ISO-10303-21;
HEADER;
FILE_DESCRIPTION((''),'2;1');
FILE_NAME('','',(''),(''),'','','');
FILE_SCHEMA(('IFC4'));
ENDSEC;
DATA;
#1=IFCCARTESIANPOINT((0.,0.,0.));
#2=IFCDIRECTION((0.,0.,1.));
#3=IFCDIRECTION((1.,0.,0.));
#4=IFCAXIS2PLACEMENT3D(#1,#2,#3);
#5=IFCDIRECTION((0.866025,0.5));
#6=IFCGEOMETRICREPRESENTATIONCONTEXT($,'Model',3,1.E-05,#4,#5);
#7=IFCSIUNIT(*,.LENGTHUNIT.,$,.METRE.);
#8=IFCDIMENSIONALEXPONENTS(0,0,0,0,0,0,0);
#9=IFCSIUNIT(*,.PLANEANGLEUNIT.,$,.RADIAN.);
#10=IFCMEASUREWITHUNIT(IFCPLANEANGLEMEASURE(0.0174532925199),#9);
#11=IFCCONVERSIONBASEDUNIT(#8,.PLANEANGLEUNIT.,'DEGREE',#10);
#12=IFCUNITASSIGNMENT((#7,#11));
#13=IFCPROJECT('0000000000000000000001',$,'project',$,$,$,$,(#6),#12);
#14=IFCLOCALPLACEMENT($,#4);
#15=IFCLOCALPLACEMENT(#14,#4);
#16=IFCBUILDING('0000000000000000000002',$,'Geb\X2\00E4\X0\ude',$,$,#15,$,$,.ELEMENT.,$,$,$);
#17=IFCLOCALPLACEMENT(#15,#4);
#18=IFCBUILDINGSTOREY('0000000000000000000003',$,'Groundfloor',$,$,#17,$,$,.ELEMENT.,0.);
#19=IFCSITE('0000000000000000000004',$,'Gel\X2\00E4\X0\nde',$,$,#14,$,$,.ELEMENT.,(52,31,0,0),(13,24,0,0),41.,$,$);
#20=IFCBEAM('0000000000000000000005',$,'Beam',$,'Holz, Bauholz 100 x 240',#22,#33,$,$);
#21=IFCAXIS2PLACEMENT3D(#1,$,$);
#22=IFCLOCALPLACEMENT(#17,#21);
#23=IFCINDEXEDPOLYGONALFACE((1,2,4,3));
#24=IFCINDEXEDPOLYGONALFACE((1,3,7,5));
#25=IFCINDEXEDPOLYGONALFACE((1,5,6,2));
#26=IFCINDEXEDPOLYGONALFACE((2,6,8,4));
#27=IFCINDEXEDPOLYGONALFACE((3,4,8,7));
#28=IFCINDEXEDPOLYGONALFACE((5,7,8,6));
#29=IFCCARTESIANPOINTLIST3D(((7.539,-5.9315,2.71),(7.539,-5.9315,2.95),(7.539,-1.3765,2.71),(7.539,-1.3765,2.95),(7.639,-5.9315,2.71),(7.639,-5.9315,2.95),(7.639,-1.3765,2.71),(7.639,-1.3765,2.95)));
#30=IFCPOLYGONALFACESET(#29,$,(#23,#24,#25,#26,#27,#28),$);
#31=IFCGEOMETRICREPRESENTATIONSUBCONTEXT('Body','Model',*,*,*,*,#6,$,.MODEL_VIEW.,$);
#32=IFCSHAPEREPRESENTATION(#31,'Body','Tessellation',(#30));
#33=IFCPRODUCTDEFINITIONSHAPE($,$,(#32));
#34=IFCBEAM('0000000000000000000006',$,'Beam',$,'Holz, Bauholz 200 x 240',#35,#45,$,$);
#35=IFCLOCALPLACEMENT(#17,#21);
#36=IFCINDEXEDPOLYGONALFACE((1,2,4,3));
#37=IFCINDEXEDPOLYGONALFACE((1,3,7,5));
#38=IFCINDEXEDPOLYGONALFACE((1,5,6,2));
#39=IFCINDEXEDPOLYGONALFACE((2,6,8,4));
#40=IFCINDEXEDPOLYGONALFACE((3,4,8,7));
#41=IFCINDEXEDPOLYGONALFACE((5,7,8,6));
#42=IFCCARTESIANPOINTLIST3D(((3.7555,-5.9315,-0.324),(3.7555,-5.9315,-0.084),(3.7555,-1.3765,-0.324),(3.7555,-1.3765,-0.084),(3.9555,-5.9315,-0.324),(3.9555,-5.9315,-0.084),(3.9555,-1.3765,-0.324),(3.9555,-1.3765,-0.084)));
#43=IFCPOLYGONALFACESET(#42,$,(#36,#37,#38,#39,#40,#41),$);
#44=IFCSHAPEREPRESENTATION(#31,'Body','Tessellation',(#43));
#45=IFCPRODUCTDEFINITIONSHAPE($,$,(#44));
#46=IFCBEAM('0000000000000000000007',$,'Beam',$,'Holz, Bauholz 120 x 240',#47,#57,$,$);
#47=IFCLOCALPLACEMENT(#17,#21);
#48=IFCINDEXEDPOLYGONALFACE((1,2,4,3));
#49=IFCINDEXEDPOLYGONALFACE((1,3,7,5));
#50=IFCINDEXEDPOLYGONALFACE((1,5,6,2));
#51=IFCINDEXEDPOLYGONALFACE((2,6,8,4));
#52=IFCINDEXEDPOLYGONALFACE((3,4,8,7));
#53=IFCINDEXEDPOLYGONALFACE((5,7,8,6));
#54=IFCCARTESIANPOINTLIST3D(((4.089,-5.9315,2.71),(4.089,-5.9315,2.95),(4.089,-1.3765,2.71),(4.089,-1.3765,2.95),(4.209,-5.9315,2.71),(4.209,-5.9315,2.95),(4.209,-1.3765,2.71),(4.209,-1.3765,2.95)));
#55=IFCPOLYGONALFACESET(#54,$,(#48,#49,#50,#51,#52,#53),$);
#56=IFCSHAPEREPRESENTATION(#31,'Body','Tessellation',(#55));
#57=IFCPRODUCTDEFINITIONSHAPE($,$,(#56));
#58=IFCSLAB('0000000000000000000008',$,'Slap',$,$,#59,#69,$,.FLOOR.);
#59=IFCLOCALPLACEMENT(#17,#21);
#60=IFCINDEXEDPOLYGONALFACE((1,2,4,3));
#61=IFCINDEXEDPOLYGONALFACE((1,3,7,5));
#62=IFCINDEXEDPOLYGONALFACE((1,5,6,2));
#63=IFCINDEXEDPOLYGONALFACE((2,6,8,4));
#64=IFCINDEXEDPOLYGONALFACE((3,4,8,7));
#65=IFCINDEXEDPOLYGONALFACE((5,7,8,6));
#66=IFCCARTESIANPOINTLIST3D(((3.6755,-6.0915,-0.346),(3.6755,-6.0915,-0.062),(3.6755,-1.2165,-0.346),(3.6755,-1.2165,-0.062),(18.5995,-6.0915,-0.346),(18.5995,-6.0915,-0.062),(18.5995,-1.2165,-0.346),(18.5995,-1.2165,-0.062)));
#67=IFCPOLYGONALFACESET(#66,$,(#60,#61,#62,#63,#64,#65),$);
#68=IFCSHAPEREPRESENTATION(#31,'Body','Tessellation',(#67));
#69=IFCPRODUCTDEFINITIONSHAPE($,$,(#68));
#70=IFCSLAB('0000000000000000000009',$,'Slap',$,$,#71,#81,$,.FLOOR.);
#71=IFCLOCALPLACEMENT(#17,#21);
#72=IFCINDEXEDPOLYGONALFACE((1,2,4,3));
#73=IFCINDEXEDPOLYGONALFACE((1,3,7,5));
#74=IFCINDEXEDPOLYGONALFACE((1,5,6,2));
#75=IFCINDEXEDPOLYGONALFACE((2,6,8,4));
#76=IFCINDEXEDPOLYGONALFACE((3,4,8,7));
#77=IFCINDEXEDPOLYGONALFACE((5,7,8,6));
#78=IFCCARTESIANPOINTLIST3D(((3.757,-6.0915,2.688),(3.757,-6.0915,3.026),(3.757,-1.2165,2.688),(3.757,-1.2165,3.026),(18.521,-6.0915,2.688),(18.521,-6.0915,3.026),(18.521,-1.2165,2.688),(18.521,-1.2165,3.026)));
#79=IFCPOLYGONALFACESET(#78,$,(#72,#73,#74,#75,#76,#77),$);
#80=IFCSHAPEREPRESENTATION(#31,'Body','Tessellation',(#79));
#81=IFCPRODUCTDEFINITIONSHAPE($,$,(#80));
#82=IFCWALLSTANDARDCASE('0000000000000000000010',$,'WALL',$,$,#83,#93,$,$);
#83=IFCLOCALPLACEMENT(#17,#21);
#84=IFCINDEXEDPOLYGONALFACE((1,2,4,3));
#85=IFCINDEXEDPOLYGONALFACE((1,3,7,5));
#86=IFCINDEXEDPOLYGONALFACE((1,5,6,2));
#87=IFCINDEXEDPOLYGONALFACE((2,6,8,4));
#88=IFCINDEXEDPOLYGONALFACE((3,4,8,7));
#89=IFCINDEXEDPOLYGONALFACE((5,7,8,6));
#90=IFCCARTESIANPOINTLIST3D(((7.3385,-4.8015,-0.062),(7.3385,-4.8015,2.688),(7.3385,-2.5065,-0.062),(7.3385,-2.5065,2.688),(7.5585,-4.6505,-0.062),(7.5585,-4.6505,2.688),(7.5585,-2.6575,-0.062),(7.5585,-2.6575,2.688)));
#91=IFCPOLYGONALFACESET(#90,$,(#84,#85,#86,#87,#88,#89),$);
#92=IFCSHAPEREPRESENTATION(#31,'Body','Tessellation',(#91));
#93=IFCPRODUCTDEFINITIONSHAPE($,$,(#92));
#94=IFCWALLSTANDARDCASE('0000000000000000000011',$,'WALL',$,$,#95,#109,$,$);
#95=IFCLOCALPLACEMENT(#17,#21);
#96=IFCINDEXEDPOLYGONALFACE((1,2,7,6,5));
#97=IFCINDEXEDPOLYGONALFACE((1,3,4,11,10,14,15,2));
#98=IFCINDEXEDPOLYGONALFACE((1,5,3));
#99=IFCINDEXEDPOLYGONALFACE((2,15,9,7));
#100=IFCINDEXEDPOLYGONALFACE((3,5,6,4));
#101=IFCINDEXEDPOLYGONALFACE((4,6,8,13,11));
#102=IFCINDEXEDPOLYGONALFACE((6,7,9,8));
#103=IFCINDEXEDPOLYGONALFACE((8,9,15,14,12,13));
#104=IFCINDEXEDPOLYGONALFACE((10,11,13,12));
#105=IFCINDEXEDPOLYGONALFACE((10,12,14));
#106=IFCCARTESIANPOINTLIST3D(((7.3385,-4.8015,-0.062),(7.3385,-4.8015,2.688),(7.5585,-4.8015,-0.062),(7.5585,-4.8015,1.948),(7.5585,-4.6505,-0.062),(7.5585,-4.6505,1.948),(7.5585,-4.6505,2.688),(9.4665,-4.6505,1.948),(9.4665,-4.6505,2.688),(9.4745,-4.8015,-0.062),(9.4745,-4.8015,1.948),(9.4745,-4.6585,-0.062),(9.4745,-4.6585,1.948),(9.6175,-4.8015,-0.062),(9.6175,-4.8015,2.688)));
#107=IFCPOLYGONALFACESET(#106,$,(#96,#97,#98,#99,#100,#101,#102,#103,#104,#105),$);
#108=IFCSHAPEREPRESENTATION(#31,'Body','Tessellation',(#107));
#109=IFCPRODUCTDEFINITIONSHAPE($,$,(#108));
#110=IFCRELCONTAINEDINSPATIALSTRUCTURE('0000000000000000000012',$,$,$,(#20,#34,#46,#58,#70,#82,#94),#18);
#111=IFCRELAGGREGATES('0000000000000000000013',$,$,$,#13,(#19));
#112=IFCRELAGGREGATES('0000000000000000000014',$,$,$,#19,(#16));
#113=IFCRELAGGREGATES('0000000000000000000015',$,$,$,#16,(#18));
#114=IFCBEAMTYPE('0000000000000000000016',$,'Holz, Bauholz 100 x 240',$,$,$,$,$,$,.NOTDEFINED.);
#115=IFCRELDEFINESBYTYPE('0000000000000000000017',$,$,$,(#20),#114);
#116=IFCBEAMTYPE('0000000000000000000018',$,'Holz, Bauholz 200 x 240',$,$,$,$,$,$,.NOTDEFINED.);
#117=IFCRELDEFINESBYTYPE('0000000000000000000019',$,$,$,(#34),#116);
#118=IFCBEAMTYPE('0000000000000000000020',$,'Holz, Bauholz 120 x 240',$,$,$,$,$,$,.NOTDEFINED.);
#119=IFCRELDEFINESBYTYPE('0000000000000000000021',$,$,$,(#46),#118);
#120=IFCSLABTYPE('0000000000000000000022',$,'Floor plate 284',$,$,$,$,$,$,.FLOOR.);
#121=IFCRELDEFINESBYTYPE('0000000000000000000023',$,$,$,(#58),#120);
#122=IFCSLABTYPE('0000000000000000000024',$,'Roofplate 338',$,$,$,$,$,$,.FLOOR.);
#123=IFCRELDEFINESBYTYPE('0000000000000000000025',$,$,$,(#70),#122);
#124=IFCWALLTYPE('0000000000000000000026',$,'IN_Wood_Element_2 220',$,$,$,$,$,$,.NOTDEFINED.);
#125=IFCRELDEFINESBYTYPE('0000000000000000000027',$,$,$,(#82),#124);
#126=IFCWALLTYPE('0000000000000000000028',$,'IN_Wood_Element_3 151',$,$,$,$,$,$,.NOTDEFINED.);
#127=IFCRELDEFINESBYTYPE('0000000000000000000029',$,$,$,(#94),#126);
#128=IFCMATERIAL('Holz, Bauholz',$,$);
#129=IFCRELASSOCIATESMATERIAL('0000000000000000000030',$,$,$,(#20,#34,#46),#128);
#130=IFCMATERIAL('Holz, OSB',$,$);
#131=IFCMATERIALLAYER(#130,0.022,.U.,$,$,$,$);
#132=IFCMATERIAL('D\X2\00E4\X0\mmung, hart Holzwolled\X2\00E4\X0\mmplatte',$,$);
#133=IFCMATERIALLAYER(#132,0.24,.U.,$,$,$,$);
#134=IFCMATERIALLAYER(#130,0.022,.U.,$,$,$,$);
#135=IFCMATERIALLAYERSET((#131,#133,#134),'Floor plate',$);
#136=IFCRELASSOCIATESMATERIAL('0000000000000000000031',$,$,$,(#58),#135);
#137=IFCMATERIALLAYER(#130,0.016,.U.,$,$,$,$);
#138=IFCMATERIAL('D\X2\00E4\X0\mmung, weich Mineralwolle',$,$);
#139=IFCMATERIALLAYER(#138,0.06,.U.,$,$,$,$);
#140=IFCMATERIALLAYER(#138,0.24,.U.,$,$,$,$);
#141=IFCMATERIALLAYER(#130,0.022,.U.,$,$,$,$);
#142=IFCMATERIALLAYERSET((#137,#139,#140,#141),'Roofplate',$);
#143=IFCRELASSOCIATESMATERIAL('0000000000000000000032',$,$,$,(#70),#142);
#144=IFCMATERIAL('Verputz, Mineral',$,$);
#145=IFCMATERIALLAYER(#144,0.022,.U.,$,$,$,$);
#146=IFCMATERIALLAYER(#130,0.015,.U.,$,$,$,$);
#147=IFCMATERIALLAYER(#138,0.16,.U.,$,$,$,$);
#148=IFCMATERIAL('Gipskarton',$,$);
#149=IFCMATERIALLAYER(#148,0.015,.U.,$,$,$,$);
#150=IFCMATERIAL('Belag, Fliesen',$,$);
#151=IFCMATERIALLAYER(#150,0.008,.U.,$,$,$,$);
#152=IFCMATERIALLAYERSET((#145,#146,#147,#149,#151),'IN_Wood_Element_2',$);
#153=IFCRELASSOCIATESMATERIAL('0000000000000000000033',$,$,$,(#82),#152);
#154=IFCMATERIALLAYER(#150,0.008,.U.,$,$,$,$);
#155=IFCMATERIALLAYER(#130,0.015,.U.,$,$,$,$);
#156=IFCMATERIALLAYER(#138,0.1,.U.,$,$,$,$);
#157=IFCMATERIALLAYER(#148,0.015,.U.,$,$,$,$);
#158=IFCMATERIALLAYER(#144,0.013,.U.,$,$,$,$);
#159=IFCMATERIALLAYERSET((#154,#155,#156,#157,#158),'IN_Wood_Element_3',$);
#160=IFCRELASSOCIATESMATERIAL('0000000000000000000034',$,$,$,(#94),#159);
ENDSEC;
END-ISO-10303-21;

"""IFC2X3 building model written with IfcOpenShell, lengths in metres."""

from ifc_helpers import new_model, entity, si_unit, converted_unit, direction, frame, frame_2d, origin_with_axes, origin_2d_with_axis, place, context, subcontext, project, spatial, polyline, rectangle, outline, extrude, material, layer, layer_set, layer_usage, type_object, element, save


model = new_model("IFC2X3")

# Units and contexts
model_context = context("Model", 3, precision=1e-05, world=origin_with_axes(), true_north=direction((0.866025, 0.5)))
body_context = subcontext(model_context, "Body", "Model", "MODEL_VIEW")
ifc_project = project(units=[si_unit("LENGTHUNIT", "METRE"), converted_unit("PLANEANGLEUNIT", "DEGREE", entity("IfcPlaneAngleMeasure", 0.0174532925199), si_unit("PLANEANGLEUNIT", "RADIAN"), dimensions=[0, 0, 0, 0, 0, 0, 0])], contexts=[model_context])

# Site, building, storey
site_placement = place(None, origin_with_axes())
site = spatial("IfcSite", under=ifc_project, at=site_placement, Name="Gelände", CompositionType="ELEMENT", RefLatitude=(52, 31, 0, 0), RefLongitude=(13, 24, 0, 0), RefElevation=41.0)
building_placement = place(site_placement, origin_with_axes())
building = spatial("IfcBuilding", under=site, at=building_placement, Name="Gebäude", CompositionType="ELEMENT")
storey_placement = place(building_placement, origin_with_axes())
storey = spatial("IfcBuildingStorey", under=building, at=storey_placement, Name="Groundfloor", CompositionType="ELEMENT", Elevation=0.0)

# Shared definitions
ifc_material_1 = material(Name="Holz, Bauholz")

# Beams
beam_type_1 = type_object("IfcBeamType", Name="Holz, Bauholz 100 x 240", PredefinedType="NOTDEFINED")
for number, where, z_axis, x_axis, name in (
    (1, (7.589, -5.9315, 2.95), (0.0, 0.0, 1.0), (1.0, 0.0, 0.0), "Beam"),
):
    element("IfcBeam", number, at=place(storey_placement, frame(where, z_axis=z_axis, x_axis=x_axis)), inside=storey, type_object=beam_type_1, material=ifc_material_1, Name=name, ObjectType="Holz, Bauholz 100 x 240", context=body_context, shape_type="SweptSolid", body=[
        extrude(rectangle(XDim=0.24, YDim=0.1, at=frame_2d((-0.12, 0.0), x_axis=(1.0, 0.0))), frame((0.0, 0.0, 0.0), z_axis=(0.0, 1.0, 0.0), x_axis=(0.0, 0.0, 1.0)), (0.0, 0.0, 1.0), 4.555),
    ])
beam_type_2 = type_object("IfcBeamType", Name="Holz, Bauholz 200 x 240", PredefinedType="NOTDEFINED")
beam_1_placement = place(storey_placement, frame((3.8555, -5.9315, -0.084), z_axis=(0.0, 0.0, 1.0), x_axis=(1.0, 0.0, 0.0)))
element("IfcBeam", 2, at=beam_1_placement, inside=storey, type_object=beam_type_2, material=ifc_material_1, Name="Beam", ObjectType="Holz, Bauholz 200 x 240", context=body_context, shape_type="SweptSolid", body=[
    extrude(rectangle(XDim=0.24, YDim=0.2, at=frame_2d((-0.12, 0.0), x_axis=(1.0, 0.0))), frame((0.0, 0.0, 0.0), z_axis=(0.0, 1.0, 0.0), x_axis=(0.0, 0.0, 1.0)), (0.0, 0.0, 1.0), 4.555),
])
beam_type_3 = type_object("IfcBeamType", Name="Holz, Bauholz 120 x 240", PredefinedType="NOTDEFINED")
beam_2_placement = place(storey_placement, frame((4.149, -5.9315, 2.95), z_axis=(0.0, 0.0, 1.0), x_axis=(1.0, 0.0, 0.0)))
element("IfcBeam", 3, at=beam_2_placement, inside=storey, type_object=beam_type_3, material=ifc_material_1, Name="Beam", ObjectType="Holz, Bauholz 120 x 240", context=body_context, shape_type="SweptSolid", body=[
    extrude(rectangle(XDim=0.24, YDim=0.12, at=frame_2d((-0.12, 0.0), x_axis=(1.0, 0.0))), frame((0.0, 0.0, 0.0), z_axis=(0.0, 1.0, 0.0), x_axis=(0.0, 0.0, 1.0)), (0.0, 0.0, 1.0), 4.555),
])

# Slabs
ifc_material_2 = material(Name="Holz, OSB")
ifc_layer_1 = layer(ifc_material_2, 0.022, ventilated="UNKNOWN")
ifc_material_3 = material(Name="Dämmung, hart Holzwolledämmplatte")
ifc_layer_2 = layer(ifc_material_3, 0.24, ventilated="UNKNOWN")
ifc_layer_3 = layer(ifc_material_2, 0.022, ventilated="UNKNOWN")
ifc_layer_set_1 = layer_set([ifc_layer_1, ifc_layer_2, ifc_layer_3], Name="Floor plate")
ifc_layer_usage_1 = layer_usage(ifc_layer_set_1, "AXIS3", "NEGATIVE", 0.284)
slab_type_1 = type_object("IfcSlabType", Name="Floor plate 284", PredefinedType="FLOOR")
slab_1_placement = place(storey_placement, frame((3.6755, -6.0915, -0.062), z_axis=(0.0, 0.0, 1.0), x_axis=(1.0, 0.0, 0.0)))
element("IfcSlab", 4, at=slab_1_placement, inside=storey, type_object=slab_type_1, material=ifc_layer_usage_1, Name="Slap", PredefinedType="FLOOR", context=body_context, shape_type="SweptSolid", body=[
    extrude(outline(polyline([(0.0, 0.0), (14.924, 0.0), (14.924, 4.875), (0.0, 4.875), (0.0, 0.0)])), frame((0.0, 0.0, -0.284), z_axis=(0.0, 0.0, 1.0), x_axis=(1.0, 0.0, 0.0)), (0.0, 0.0, 1.0), 0.284),
])
ifc_layer_4 = layer(ifc_material_2, 0.016, ventilated="UNKNOWN")
ifc_material_4 = material(Name="Dämmung, weich Mineralwolle")
ifc_layer_5 = layer(ifc_material_4, 0.06, ventilated="UNKNOWN")
ifc_layer_6 = layer(ifc_material_4, 0.24, ventilated="UNKNOWN")
ifc_layer_7 = layer(ifc_material_2, 0.022, ventilated="UNKNOWN")
ifc_layer_set_2 = layer_set([ifc_layer_4, ifc_layer_5, ifc_layer_6, ifc_layer_7], Name="Roofplate")
ifc_layer_usage_2 = layer_usage(ifc_layer_set_2, "AXIS3", "NEGATIVE", 0.338)
slab_type_2 = type_object("IfcSlabType", Name="Roofplate 338", PredefinedType="FLOOR")
slab_2_placement = place(storey_placement, frame((3.757, -6.0915, 3.026), z_axis=(0.0, 0.0, 1.0), x_axis=(1.0, 0.0, 0.0)))
element("IfcSlab", 5, at=slab_2_placement, inside=storey, type_object=slab_type_2, material=ifc_layer_usage_2, Name="Slap", PredefinedType="FLOOR", context=body_context, shape_type="SweptSolid", body=[
    extrude(outline(polyline([(0.0, 0.0), (14.764, 0.0), (14.764, 4.875), (0.0, 4.875), (0.0, 0.0)])), frame((0.0, 0.0, -0.338), z_axis=(0.0, 0.0, 1.0), x_axis=(1.0, 0.0, 0.0)), (0.0, 0.0, 1.0), 0.338),
])

# Wall
ifc_material_5 = material(Name="Verputz, Mineral")
ifc_material_6 = material(Name="Gipskarton")
ifc_layer_8 = layer(ifc_material_5, 0.022, ventilated="UNKNOWN")
ifc_layer_9 = layer(ifc_material_2, 0.015, ventilated="UNKNOWN")
ifc_layer_10 = layer(ifc_material_4, 0.16, ventilated="UNKNOWN")
ifc_layer_11 = layer(ifc_material_6, 0.015, ventilated="UNKNOWN")
ifc_material_7 = material(Name="Belag, Fliesen")
ifc_layer_12 = layer(ifc_material_7, 0.008, ventilated="UNKNOWN")
ifc_layer_set_3 = layer_set([ifc_layer_8, ifc_layer_9, ifc_layer_10, ifc_layer_11, ifc_layer_12], Name="IN_Wood_Element_2")
ifc_layer_usage_3 = layer_usage(ifc_layer_set_3, "AXIS2", "NEGATIVE", 0.22)
wall_type_1 = type_object("IfcWallType", Name="IN_Wood_Element_2 220", PredefinedType="NOTDEFINED")
wall_1_placement = place(storey_placement, frame((7.5585, -4.8015, -0.062), z_axis=(0.0, 0.0, 1.0), x_axis=(0.0, 1.0, 0.0)))
element("IfcWallStandardCase", 6, at=wall_1_placement, inside=storey, type_object=wall_type_1, material=ifc_layer_usage_3, Name="WALL", context=body_context, shape_type="SweptSolid", body=[
    extrude(outline(polyline([(0.151, 0.0), (2.144, 0.0), (2.295, 0.22), (0.0, 0.22), (0.151, 0.0)])), origin_with_axes(), (0.0, 0.0, 1.0), 2.75),
])

# Wall, opening
ifc_layer_13 = layer(ifc_material_7, 0.008, ventilated="UNKNOWN")
ifc_layer_14 = layer(ifc_material_2, 0.015, ventilated="UNKNOWN")
ifc_layer_15 = layer(ifc_material_4, 0.1, ventilated="UNKNOWN")
ifc_layer_16 = layer(ifc_material_6, 0.015, ventilated="UNKNOWN")
ifc_layer_17 = layer(ifc_material_5, 0.013, ventilated="UNKNOWN")
ifc_layer_set_4 = layer_set([ifc_layer_13, ifc_layer_14, ifc_layer_15, ifc_layer_16, ifc_layer_17], Name="IN_Wood_Element_3")
ifc_layer_usage_4 = layer_usage(ifc_layer_set_4, "AXIS2", "NEGATIVE", 0.151)
wall_type_2 = type_object("IfcWallType", Name="IN_Wood_Element_3 151", PredefinedType="NOTDEFINED")
wall_2_placement = place(storey_placement, frame((7.5585, -4.8015, -0.062), z_axis=(0.0, 0.0, 1.0), x_axis=(1.0, 0.0, 0.0)))
wall_2 = element("IfcWallStandardCase", 7, at=wall_2_placement, inside=storey, type_object=wall_type_2, material=ifc_layer_usage_4, Name="WALL", context=body_context, shape_type="SweptSolid", body=[
    extrude(outline(polyline([(-0.22, 0.0), (2.059, 0.0), (1.908, 0.151), (0.0, 0.151), (-0.22, 0.0)])), origin_with_axes(), (0.0, 0.0, 1.0), 2.75),
])
opening_1_placement = place(wall_2_placement, frame((0.958, 0.0, 0.0), z_axis=(0.0, 0.0, 1.0), x_axis=(1.0, 0.0, 0.0)))
element("IfcOpeningElement", 8, at=opening_1_placement, cuts=wall_2, context=body_context, shape_type="SweptSolid", body=[
    extrude(rectangle(XDim=1.916, YDim=2.01, at=origin_2d_with_axis()), frame((0.0, 0.151, 1.005), z_axis=(0.0, -1.0, 0.0), x_axis=(-1.0, 0.0, 0.0)), (0.0, 0.0, 1.0), 0.453),
])

save(model, "model.ifc")
